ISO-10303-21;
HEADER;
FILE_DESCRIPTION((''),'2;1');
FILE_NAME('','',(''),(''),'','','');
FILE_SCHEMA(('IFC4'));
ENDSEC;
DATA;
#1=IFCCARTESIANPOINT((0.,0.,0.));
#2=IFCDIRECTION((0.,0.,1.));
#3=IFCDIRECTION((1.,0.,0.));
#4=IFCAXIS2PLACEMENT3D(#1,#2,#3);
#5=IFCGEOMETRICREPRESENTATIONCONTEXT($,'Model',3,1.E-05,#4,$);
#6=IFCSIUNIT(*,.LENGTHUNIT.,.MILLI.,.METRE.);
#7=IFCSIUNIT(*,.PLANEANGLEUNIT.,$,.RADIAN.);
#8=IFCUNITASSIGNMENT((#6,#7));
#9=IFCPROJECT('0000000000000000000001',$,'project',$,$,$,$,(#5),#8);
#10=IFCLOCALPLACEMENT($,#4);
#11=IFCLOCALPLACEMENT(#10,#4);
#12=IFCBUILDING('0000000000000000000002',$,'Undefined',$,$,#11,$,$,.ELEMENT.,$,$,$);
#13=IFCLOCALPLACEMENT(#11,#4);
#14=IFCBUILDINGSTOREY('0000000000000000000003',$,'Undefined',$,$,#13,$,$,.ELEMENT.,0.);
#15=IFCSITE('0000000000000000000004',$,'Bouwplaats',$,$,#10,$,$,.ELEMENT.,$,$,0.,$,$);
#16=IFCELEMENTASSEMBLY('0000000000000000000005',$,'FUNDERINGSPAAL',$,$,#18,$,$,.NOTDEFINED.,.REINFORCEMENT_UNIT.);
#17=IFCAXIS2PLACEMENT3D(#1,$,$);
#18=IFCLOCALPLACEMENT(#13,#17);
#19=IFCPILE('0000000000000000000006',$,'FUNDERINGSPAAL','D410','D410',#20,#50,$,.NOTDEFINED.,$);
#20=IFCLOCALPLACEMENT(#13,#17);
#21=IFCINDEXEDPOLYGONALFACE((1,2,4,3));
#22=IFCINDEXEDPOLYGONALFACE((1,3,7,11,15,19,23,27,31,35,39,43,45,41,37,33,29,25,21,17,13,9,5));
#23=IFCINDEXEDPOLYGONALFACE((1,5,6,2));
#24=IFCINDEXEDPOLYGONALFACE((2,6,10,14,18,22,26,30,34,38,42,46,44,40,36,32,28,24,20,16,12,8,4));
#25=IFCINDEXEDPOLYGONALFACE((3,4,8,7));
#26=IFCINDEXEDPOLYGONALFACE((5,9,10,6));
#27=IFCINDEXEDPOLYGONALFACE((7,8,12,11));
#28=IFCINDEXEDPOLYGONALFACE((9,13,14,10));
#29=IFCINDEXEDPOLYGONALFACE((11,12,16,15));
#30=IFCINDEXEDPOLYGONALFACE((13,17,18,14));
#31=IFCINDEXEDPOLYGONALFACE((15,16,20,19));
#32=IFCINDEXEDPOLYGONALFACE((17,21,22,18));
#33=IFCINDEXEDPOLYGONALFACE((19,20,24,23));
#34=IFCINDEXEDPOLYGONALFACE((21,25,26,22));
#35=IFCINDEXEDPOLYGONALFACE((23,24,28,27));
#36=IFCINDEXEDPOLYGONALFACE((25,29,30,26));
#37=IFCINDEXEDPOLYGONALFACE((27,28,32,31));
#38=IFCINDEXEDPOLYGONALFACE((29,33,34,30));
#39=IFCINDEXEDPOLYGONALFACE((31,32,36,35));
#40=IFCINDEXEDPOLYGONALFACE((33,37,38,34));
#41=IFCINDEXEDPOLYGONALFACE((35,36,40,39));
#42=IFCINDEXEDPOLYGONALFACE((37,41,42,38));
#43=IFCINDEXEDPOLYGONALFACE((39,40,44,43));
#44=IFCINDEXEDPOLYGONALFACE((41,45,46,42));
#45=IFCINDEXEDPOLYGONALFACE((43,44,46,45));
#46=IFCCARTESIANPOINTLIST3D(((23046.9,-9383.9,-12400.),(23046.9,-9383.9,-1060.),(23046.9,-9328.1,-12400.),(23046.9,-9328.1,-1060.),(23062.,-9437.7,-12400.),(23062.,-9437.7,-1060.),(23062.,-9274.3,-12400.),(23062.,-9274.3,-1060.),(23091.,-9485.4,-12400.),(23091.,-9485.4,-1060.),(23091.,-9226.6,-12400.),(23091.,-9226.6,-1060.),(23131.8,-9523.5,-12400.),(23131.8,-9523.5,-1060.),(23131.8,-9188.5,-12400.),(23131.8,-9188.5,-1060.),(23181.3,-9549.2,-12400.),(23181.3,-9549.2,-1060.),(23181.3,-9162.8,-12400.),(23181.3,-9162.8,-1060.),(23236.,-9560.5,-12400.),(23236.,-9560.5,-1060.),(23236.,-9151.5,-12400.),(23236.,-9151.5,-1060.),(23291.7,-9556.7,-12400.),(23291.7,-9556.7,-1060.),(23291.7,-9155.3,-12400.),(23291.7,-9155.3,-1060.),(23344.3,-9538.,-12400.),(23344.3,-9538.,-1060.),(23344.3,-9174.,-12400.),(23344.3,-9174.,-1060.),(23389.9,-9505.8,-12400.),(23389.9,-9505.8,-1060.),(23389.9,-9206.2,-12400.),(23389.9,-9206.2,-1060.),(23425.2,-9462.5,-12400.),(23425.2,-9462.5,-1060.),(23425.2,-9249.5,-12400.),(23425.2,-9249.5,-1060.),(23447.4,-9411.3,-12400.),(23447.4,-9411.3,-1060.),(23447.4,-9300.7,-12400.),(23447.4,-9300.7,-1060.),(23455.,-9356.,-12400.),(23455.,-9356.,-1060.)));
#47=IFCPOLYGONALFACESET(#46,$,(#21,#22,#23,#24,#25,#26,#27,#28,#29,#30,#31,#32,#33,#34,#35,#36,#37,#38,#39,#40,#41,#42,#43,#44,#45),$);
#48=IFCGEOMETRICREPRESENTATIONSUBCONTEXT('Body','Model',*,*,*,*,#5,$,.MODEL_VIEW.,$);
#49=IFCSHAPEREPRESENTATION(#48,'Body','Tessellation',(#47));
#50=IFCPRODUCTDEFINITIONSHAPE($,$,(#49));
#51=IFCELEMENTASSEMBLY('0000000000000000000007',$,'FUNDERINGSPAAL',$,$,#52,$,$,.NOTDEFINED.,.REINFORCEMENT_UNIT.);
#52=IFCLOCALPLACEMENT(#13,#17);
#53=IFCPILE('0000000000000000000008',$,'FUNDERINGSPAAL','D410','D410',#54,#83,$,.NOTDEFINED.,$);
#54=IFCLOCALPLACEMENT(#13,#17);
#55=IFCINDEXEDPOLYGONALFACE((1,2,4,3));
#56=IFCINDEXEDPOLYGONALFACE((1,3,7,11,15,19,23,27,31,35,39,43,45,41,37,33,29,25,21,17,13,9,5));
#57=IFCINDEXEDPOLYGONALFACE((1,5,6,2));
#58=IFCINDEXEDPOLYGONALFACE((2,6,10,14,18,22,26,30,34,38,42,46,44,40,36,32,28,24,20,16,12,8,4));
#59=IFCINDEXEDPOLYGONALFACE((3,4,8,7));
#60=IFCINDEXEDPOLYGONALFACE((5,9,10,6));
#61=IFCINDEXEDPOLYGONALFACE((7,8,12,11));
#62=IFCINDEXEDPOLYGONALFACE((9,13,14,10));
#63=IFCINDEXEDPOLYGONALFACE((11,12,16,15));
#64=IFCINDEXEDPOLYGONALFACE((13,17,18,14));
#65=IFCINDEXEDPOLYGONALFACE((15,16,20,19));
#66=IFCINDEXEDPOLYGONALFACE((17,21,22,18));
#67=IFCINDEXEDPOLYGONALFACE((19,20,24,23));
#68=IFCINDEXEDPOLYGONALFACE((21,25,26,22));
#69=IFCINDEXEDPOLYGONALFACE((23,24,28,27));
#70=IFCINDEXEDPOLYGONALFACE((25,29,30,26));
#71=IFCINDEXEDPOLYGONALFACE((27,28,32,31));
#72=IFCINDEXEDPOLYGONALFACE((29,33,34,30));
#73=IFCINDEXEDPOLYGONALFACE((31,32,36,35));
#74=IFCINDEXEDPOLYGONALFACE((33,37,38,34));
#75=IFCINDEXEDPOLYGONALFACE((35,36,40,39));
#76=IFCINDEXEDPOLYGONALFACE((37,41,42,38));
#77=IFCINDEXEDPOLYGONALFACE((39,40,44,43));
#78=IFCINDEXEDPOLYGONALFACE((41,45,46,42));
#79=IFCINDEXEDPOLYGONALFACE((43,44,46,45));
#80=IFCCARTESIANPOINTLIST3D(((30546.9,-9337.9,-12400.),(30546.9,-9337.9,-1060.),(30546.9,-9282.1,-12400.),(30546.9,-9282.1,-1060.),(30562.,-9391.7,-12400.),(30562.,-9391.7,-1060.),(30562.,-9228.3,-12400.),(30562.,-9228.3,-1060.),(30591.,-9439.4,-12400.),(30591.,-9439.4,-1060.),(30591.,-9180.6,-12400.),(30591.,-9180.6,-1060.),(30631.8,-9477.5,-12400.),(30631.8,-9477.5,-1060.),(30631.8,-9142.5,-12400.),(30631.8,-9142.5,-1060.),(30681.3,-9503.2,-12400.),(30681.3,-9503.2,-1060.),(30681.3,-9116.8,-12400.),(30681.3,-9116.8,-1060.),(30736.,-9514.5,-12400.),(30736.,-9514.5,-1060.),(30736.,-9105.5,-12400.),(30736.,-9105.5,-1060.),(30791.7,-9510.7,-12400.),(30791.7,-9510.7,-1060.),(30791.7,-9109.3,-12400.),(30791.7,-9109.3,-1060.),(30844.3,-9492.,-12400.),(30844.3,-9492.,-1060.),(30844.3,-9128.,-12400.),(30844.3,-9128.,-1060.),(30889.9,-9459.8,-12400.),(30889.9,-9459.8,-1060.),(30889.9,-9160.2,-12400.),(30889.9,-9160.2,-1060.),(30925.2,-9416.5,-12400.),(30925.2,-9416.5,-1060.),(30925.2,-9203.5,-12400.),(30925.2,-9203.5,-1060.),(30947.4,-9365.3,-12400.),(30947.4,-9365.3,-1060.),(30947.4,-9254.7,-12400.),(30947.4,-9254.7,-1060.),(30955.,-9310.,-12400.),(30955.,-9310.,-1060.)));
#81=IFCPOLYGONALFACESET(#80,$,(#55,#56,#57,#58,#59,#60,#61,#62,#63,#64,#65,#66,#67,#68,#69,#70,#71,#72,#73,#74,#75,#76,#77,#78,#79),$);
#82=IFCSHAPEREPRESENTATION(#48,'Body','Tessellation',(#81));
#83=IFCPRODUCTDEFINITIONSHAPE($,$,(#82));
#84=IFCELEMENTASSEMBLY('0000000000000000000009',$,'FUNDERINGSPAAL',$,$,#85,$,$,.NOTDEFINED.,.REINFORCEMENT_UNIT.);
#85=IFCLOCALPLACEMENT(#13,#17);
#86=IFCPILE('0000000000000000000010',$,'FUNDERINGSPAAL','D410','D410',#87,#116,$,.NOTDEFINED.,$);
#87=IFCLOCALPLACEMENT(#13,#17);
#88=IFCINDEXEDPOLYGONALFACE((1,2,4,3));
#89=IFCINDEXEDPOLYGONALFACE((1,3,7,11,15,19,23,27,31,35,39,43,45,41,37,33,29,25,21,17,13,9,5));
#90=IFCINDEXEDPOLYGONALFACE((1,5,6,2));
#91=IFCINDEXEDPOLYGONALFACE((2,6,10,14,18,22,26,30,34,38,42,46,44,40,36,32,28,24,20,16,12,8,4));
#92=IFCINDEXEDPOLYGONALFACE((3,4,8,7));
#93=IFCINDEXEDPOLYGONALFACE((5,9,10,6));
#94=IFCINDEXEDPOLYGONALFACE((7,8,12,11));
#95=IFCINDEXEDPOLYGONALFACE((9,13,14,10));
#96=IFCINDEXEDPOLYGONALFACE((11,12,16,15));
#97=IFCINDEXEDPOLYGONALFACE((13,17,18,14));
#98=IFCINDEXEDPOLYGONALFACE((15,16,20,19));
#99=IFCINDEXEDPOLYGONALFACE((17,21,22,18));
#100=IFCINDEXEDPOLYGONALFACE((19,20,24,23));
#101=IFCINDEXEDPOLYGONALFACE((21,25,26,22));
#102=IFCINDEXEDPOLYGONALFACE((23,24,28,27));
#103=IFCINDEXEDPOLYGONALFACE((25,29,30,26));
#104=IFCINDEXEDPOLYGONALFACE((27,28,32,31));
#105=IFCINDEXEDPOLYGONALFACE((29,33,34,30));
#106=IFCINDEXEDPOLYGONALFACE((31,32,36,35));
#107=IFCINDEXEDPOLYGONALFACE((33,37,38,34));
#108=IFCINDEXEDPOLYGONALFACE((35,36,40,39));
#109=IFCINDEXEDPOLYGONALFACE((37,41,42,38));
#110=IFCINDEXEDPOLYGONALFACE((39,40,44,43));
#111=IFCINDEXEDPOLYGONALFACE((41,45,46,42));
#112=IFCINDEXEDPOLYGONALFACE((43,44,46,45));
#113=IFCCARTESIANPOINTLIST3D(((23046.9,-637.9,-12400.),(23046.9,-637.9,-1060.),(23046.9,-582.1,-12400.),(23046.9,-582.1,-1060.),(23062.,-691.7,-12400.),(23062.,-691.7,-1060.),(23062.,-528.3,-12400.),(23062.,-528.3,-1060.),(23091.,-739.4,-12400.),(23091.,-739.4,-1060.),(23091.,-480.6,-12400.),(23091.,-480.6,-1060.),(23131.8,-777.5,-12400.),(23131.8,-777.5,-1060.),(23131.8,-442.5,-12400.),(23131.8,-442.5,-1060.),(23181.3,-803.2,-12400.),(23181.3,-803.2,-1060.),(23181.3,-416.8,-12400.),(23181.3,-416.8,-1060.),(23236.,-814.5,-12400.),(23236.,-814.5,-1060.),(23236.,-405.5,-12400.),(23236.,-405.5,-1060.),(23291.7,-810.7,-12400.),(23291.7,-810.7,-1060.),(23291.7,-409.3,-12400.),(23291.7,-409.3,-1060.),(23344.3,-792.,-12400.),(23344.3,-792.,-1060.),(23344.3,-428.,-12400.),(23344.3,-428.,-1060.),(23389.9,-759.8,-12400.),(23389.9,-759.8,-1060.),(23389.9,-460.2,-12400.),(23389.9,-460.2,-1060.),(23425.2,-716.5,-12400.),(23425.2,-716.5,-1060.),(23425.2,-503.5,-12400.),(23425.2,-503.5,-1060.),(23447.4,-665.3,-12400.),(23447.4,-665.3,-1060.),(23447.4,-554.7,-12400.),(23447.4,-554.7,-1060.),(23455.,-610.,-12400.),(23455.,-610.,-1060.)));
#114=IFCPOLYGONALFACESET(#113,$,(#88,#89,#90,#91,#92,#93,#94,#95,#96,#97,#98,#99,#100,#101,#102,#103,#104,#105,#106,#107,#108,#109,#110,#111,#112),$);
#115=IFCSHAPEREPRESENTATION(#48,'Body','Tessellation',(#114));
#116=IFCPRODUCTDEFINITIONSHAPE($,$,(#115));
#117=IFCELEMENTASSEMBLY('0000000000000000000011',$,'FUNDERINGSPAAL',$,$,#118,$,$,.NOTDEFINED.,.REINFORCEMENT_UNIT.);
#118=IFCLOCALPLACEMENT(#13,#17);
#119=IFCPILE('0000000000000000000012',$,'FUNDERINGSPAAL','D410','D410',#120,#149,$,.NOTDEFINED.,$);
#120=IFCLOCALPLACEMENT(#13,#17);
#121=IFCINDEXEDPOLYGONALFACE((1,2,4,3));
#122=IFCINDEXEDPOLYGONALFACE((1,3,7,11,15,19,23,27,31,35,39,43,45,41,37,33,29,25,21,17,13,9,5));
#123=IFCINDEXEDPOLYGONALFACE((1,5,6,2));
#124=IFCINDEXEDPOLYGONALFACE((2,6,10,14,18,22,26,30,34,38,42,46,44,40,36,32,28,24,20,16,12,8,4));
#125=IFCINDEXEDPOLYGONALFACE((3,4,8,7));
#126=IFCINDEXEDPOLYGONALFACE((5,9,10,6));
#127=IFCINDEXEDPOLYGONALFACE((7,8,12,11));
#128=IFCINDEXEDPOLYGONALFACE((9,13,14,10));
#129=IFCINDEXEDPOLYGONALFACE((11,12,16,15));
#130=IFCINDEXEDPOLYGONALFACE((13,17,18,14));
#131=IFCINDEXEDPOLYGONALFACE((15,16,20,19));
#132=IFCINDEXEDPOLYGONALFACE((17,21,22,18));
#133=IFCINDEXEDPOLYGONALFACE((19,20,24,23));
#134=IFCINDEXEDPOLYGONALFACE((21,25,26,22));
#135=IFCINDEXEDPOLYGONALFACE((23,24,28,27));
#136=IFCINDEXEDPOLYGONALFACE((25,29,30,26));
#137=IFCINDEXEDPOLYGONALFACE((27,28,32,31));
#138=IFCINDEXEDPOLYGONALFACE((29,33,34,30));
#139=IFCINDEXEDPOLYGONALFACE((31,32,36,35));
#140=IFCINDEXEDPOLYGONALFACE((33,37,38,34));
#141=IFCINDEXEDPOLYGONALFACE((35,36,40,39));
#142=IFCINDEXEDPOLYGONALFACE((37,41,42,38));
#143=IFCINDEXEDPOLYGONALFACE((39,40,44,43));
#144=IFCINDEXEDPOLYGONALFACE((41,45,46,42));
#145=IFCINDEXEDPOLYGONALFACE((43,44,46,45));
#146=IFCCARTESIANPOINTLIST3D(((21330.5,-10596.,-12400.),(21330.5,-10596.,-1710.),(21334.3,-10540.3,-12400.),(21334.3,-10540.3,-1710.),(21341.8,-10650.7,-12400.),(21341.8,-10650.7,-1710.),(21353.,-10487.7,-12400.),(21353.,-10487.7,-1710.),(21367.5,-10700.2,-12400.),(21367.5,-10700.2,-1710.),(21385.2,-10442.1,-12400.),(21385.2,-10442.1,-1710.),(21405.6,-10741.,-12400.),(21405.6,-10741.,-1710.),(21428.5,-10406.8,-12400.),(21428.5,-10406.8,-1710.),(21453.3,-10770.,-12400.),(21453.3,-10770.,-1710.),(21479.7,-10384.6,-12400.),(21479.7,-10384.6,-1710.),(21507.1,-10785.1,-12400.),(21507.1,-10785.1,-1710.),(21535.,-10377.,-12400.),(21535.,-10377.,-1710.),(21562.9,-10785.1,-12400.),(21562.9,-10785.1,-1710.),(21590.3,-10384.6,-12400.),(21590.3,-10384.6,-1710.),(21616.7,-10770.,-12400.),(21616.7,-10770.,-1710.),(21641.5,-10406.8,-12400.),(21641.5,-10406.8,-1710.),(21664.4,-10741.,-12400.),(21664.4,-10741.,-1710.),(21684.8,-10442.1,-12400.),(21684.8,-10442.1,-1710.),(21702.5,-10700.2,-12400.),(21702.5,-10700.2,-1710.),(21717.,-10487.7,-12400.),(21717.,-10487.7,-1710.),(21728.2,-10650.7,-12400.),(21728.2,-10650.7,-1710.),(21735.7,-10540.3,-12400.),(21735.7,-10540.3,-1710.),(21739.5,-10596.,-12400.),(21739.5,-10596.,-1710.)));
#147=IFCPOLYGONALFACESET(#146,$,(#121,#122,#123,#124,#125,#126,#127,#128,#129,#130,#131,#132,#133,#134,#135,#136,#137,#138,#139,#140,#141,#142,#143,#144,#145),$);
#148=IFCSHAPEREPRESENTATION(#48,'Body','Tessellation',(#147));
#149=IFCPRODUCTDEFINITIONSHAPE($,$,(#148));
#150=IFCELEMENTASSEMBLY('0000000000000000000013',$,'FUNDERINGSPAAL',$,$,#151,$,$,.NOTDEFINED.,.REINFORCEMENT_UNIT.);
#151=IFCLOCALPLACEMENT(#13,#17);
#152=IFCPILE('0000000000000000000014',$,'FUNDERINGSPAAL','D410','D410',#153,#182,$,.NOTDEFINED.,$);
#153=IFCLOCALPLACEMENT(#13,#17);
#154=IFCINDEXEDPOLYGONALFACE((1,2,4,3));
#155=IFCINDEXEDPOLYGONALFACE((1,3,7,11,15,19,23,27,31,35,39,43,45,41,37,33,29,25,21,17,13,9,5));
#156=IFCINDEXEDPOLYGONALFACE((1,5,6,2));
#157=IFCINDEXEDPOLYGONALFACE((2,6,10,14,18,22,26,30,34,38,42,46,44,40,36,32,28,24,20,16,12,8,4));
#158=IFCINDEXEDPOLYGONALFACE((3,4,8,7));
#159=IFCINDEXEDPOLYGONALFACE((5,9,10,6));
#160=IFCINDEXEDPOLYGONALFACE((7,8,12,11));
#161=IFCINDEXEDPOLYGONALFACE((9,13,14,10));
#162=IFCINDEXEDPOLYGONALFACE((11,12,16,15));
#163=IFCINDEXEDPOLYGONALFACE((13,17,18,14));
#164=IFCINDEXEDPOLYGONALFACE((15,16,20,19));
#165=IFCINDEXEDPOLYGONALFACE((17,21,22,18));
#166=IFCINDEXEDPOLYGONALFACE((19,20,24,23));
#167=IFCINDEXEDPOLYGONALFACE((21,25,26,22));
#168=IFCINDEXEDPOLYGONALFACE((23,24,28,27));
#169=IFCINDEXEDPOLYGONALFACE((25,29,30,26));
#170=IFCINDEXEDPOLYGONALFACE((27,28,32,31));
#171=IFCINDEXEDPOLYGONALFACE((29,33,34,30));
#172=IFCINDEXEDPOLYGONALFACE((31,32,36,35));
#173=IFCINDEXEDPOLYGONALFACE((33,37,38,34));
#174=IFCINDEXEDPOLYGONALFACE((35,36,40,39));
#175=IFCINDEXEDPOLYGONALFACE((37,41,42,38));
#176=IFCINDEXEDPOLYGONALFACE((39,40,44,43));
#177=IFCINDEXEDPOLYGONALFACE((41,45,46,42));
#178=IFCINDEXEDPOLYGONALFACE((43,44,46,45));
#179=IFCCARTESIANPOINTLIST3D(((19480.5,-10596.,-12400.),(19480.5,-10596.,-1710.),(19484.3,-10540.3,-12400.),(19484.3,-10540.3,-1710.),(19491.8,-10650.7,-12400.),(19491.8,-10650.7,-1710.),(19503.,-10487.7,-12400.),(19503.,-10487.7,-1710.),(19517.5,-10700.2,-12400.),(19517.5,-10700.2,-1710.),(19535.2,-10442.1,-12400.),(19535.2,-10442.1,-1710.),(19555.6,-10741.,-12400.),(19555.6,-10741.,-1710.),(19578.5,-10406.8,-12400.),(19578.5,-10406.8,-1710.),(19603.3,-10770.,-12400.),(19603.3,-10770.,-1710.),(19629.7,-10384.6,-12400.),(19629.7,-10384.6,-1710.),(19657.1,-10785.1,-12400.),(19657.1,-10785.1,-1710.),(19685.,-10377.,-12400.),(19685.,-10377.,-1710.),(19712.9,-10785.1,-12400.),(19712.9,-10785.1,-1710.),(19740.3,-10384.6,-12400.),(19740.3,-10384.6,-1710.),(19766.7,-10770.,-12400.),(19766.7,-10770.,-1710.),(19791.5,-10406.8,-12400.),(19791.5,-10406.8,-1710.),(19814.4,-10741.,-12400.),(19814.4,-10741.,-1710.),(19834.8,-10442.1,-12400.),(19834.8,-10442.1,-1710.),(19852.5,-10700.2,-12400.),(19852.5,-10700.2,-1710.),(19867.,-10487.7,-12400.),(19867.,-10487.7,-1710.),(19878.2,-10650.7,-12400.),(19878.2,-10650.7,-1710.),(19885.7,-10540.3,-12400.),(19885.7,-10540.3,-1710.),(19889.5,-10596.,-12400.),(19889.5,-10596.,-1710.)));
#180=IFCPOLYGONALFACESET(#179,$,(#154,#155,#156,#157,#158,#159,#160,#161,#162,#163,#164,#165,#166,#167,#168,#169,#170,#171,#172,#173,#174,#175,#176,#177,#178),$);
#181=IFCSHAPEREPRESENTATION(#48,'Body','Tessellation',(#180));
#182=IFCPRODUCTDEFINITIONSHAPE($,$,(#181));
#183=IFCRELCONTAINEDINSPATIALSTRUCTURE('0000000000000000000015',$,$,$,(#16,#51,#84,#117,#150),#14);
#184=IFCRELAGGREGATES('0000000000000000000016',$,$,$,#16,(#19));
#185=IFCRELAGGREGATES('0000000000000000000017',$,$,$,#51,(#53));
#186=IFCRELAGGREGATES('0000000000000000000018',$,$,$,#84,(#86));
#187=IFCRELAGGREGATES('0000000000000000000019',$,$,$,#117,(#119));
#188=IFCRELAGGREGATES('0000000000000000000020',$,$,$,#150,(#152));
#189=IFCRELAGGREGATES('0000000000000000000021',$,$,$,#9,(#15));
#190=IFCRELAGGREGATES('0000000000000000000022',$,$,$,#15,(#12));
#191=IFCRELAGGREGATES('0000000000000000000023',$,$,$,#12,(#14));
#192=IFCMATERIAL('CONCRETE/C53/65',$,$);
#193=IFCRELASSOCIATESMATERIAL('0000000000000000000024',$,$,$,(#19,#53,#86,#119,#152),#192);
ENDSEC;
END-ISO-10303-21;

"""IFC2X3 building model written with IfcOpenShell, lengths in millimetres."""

from ifc_helpers import new_model, si_unit, frame, origin_with_axes, origin_2d_with_axis, place, context, subcontext, project, spatial, circle, extrude, clip, halfspace, material, element, aggregate, save


model = new_model("IFC2X3")

# Units and contexts
model_context = context("Model", 3, precision=1e-05, world=origin_with_axes())
body_context = subcontext(model_context, "Body", "Model", "MODEL_VIEW")
ifc_project = project(units=[si_unit("LENGTHUNIT", "METRE", prefix="MILLI"), si_unit("PLANEANGLEUNIT", "RADIAN")], contexts=[model_context])

# Site, building, storey
site_placement = place(None, origin_with_axes())
site = spatial("IfcSite", under=ifc_project, at=site_placement, Name="Bouwplaats", CompositionType="ELEMENT", RefElevation=0.0)
building_placement = place(site_placement, origin_with_axes())
building = spatial("IfcBuilding", under=site, at=building_placement, Name="Undefined", CompositionType="ELEMENT")
storey_placement = place(building_placement, origin_with_axes())
storey = spatial("IfcBuildingStorey", under=building, at=storey_placement, Name="Undefined", CompositionType="ELEMENT", Elevation=0.0)

# Element assemblies, piles
assembly_1_placement = place(storey_placement, origin_with_axes())
assembly_1 = element("IfcElementAssembly", 1, at=assembly_1_placement, inside=storey, Name="FUNDERINGSPAAL", AssemblyPlace="NOTDEFINED", PredefinedType="REINFORCEMENT_UNIT")
ifc_material_1 = material(Name="CONCRETE/C53/65")
pile_1_placement = place(assembly_1_placement, frame((23250.0, -9356.0, -1060.0), z_axis=(0.0, 1.0, 0.0), x_axis=(0.0, 0.0, -1.0)))
pile_1 = element("IfcPile", 2, at=pile_1_placement, material=ifc_material_1, Name="FUNDERINGSPAAL", Description="D410", ObjectType="D410", PredefinedType="NOTDEFINED", context=body_context, shape_type="Clipping", body=[
    clip(extrude(circle(Radius=205.0, at=origin_2d_with_axis()), frame((11340.0, 0.0, 0.0), z_axis=(-1.0, 0.0, 0.0), x_axis=(0.0, -1.0, 0.0)), (0.0, 0.0, 1.0), 11340.0), halfspace(frame((0.0, 205.0, -205.0), z_axis=(-1.0, 0.0, 0.0), x_axis=(0.0, 0.0, 1.0)), False)),
])
aggregate(assembly_1, [pile_1])
assembly_2_placement = place(storey_placement, origin_with_axes())
assembly_2 = element("IfcElementAssembly", 3, at=assembly_2_placement, inside=storey, Name="FUNDERINGSPAAL", AssemblyPlace="NOTDEFINED", PredefinedType="REINFORCEMENT_UNIT")
pile_2_placement = place(assembly_2_placement, frame((30750.0, -9310.0, -1060.0), z_axis=(0.0, 1.0, 0.0), x_axis=(0.0, 0.0, -1.0)))
pile_2 = element("IfcPile", 4, at=pile_2_placement, material=ifc_material_1, Name="FUNDERINGSPAAL", Description="D410", ObjectType="D410", PredefinedType="NOTDEFINED", context=body_context, shape_type="Clipping", body=[
    clip(extrude(circle(Radius=205.0, at=origin_2d_with_axis()), frame((11340.0, 0.0, 0.0), z_axis=(-1.0, 0.0, 0.0), x_axis=(0.0, -1.0, 0.0)), (0.0, 0.0, 1.0), 11340.0), halfspace(frame((0.0, 205.0, -205.0), z_axis=(-1.0, 0.0, 0.0), x_axis=(0.0, 0.0, 1.0)), False)),
])
aggregate(assembly_2, [pile_2])
assembly_3_placement = place(storey_placement, origin_with_axes())
assembly_3 = element("IfcElementAssembly", 5, at=assembly_3_placement, inside=storey, Name="FUNDERINGSPAAL", AssemblyPlace="NOTDEFINED", PredefinedType="REINFORCEMENT_UNIT")
pile_3_placement = place(assembly_3_placement, frame((23250.0, -610.0, -1060.0), z_axis=(0.0, 1.0, 0.0), x_axis=(0.0, 0.0, -1.0)))
pile_3 = element("IfcPile", 6, at=pile_3_placement, material=ifc_material_1, Name="FUNDERINGSPAAL", Description="D410", ObjectType="D410", PredefinedType="NOTDEFINED", context=body_context, shape_type="Clipping", body=[
    clip(extrude(circle(Radius=205.0, at=origin_2d_with_axis()), frame((11340.0, 0.0, 0.0), z_axis=(-1.0, 0.0, 0.0), x_axis=(0.0, -1.0, 0.0)), (0.0, 0.0, 1.0), 11340.0), halfspace(frame((0.0, 205.0, -205.0), z_axis=(-1.0, 0.0, 0.0), x_axis=(0.0, 0.0, 1.0)), False)),
])
aggregate(assembly_3, [pile_3])
assembly_4_placement = place(storey_placement, origin_with_axes())
assembly_4 = element("IfcElementAssembly", 7, at=assembly_4_placement, inside=storey, Name="FUNDERINGSPAAL", AssemblyPlace="NOTDEFINED", PredefinedType="REINFORCEMENT_UNIT")
pile_4_placement = place(assembly_4_placement, frame((21535.0, -10582.0, -1710.0), z_axis=(-1.0, 0.0, 0.0), x_axis=(0.0, 0.0, -1.0)))
pile_4 = element("IfcPile", 8, at=pile_4_placement, material=ifc_material_1, Name="FUNDERINGSPAAL", Description="D410", ObjectType="D410", PredefinedType="NOTDEFINED", context=body_context, shape_type="Clipping", body=[
    clip(extrude(circle(Radius=205.0, at=origin_2d_with_axis()), frame((10690.0, 0.0, 0.0), z_axis=(-1.0, 0.0, 0.0), x_axis=(0.0, -1.0, 0.0)), (0.0, 0.0, 1.0), 10690.0), halfspace(frame((0.0, 205.0, -205.0), z_axis=(-1.0, 0.0, 0.0), x_axis=(0.0, 0.0, 1.0)), False)),
])
aggregate(assembly_4, [pile_4])
assembly_5_placement = place(storey_placement, origin_with_axes())
assembly_5 = element("IfcElementAssembly", 9, at=assembly_5_placement, inside=storey, Name="FUNDERINGSPAAL", AssemblyPlace="NOTDEFINED", PredefinedType="REINFORCEMENT_UNIT")
pile_5_placement = place(assembly_5_placement, frame((19685.0, -10582.0, -1710.0), z_axis=(-1.0, 0.0, 0.0), x_axis=(0.0, 0.0, -1.0)))
pile_5 = element("IfcPile", 10, at=pile_5_placement, material=ifc_material_1, Name="FUNDERINGSPAAL", Description="D410", ObjectType="D410", PredefinedType="NOTDEFINED", context=body_context, shape_type="Clipping", body=[
    clip(extrude(circle(Radius=205.0, at=origin_2d_with_axis()), frame((10690.0, 0.0, 0.0), z_axis=(-1.0, 0.0, 0.0), x_axis=(0.0, -1.0, 0.0)), (0.0, 0.0, 1.0), 10690.0), halfspace(frame((0.0, 205.0, -205.0), z_axis=(-1.0, 0.0, 0.0), x_axis=(0.0, 0.0, 1.0)), False)),
])
aggregate(assembly_5, [pile_5])

save(model, "model.ifc")
